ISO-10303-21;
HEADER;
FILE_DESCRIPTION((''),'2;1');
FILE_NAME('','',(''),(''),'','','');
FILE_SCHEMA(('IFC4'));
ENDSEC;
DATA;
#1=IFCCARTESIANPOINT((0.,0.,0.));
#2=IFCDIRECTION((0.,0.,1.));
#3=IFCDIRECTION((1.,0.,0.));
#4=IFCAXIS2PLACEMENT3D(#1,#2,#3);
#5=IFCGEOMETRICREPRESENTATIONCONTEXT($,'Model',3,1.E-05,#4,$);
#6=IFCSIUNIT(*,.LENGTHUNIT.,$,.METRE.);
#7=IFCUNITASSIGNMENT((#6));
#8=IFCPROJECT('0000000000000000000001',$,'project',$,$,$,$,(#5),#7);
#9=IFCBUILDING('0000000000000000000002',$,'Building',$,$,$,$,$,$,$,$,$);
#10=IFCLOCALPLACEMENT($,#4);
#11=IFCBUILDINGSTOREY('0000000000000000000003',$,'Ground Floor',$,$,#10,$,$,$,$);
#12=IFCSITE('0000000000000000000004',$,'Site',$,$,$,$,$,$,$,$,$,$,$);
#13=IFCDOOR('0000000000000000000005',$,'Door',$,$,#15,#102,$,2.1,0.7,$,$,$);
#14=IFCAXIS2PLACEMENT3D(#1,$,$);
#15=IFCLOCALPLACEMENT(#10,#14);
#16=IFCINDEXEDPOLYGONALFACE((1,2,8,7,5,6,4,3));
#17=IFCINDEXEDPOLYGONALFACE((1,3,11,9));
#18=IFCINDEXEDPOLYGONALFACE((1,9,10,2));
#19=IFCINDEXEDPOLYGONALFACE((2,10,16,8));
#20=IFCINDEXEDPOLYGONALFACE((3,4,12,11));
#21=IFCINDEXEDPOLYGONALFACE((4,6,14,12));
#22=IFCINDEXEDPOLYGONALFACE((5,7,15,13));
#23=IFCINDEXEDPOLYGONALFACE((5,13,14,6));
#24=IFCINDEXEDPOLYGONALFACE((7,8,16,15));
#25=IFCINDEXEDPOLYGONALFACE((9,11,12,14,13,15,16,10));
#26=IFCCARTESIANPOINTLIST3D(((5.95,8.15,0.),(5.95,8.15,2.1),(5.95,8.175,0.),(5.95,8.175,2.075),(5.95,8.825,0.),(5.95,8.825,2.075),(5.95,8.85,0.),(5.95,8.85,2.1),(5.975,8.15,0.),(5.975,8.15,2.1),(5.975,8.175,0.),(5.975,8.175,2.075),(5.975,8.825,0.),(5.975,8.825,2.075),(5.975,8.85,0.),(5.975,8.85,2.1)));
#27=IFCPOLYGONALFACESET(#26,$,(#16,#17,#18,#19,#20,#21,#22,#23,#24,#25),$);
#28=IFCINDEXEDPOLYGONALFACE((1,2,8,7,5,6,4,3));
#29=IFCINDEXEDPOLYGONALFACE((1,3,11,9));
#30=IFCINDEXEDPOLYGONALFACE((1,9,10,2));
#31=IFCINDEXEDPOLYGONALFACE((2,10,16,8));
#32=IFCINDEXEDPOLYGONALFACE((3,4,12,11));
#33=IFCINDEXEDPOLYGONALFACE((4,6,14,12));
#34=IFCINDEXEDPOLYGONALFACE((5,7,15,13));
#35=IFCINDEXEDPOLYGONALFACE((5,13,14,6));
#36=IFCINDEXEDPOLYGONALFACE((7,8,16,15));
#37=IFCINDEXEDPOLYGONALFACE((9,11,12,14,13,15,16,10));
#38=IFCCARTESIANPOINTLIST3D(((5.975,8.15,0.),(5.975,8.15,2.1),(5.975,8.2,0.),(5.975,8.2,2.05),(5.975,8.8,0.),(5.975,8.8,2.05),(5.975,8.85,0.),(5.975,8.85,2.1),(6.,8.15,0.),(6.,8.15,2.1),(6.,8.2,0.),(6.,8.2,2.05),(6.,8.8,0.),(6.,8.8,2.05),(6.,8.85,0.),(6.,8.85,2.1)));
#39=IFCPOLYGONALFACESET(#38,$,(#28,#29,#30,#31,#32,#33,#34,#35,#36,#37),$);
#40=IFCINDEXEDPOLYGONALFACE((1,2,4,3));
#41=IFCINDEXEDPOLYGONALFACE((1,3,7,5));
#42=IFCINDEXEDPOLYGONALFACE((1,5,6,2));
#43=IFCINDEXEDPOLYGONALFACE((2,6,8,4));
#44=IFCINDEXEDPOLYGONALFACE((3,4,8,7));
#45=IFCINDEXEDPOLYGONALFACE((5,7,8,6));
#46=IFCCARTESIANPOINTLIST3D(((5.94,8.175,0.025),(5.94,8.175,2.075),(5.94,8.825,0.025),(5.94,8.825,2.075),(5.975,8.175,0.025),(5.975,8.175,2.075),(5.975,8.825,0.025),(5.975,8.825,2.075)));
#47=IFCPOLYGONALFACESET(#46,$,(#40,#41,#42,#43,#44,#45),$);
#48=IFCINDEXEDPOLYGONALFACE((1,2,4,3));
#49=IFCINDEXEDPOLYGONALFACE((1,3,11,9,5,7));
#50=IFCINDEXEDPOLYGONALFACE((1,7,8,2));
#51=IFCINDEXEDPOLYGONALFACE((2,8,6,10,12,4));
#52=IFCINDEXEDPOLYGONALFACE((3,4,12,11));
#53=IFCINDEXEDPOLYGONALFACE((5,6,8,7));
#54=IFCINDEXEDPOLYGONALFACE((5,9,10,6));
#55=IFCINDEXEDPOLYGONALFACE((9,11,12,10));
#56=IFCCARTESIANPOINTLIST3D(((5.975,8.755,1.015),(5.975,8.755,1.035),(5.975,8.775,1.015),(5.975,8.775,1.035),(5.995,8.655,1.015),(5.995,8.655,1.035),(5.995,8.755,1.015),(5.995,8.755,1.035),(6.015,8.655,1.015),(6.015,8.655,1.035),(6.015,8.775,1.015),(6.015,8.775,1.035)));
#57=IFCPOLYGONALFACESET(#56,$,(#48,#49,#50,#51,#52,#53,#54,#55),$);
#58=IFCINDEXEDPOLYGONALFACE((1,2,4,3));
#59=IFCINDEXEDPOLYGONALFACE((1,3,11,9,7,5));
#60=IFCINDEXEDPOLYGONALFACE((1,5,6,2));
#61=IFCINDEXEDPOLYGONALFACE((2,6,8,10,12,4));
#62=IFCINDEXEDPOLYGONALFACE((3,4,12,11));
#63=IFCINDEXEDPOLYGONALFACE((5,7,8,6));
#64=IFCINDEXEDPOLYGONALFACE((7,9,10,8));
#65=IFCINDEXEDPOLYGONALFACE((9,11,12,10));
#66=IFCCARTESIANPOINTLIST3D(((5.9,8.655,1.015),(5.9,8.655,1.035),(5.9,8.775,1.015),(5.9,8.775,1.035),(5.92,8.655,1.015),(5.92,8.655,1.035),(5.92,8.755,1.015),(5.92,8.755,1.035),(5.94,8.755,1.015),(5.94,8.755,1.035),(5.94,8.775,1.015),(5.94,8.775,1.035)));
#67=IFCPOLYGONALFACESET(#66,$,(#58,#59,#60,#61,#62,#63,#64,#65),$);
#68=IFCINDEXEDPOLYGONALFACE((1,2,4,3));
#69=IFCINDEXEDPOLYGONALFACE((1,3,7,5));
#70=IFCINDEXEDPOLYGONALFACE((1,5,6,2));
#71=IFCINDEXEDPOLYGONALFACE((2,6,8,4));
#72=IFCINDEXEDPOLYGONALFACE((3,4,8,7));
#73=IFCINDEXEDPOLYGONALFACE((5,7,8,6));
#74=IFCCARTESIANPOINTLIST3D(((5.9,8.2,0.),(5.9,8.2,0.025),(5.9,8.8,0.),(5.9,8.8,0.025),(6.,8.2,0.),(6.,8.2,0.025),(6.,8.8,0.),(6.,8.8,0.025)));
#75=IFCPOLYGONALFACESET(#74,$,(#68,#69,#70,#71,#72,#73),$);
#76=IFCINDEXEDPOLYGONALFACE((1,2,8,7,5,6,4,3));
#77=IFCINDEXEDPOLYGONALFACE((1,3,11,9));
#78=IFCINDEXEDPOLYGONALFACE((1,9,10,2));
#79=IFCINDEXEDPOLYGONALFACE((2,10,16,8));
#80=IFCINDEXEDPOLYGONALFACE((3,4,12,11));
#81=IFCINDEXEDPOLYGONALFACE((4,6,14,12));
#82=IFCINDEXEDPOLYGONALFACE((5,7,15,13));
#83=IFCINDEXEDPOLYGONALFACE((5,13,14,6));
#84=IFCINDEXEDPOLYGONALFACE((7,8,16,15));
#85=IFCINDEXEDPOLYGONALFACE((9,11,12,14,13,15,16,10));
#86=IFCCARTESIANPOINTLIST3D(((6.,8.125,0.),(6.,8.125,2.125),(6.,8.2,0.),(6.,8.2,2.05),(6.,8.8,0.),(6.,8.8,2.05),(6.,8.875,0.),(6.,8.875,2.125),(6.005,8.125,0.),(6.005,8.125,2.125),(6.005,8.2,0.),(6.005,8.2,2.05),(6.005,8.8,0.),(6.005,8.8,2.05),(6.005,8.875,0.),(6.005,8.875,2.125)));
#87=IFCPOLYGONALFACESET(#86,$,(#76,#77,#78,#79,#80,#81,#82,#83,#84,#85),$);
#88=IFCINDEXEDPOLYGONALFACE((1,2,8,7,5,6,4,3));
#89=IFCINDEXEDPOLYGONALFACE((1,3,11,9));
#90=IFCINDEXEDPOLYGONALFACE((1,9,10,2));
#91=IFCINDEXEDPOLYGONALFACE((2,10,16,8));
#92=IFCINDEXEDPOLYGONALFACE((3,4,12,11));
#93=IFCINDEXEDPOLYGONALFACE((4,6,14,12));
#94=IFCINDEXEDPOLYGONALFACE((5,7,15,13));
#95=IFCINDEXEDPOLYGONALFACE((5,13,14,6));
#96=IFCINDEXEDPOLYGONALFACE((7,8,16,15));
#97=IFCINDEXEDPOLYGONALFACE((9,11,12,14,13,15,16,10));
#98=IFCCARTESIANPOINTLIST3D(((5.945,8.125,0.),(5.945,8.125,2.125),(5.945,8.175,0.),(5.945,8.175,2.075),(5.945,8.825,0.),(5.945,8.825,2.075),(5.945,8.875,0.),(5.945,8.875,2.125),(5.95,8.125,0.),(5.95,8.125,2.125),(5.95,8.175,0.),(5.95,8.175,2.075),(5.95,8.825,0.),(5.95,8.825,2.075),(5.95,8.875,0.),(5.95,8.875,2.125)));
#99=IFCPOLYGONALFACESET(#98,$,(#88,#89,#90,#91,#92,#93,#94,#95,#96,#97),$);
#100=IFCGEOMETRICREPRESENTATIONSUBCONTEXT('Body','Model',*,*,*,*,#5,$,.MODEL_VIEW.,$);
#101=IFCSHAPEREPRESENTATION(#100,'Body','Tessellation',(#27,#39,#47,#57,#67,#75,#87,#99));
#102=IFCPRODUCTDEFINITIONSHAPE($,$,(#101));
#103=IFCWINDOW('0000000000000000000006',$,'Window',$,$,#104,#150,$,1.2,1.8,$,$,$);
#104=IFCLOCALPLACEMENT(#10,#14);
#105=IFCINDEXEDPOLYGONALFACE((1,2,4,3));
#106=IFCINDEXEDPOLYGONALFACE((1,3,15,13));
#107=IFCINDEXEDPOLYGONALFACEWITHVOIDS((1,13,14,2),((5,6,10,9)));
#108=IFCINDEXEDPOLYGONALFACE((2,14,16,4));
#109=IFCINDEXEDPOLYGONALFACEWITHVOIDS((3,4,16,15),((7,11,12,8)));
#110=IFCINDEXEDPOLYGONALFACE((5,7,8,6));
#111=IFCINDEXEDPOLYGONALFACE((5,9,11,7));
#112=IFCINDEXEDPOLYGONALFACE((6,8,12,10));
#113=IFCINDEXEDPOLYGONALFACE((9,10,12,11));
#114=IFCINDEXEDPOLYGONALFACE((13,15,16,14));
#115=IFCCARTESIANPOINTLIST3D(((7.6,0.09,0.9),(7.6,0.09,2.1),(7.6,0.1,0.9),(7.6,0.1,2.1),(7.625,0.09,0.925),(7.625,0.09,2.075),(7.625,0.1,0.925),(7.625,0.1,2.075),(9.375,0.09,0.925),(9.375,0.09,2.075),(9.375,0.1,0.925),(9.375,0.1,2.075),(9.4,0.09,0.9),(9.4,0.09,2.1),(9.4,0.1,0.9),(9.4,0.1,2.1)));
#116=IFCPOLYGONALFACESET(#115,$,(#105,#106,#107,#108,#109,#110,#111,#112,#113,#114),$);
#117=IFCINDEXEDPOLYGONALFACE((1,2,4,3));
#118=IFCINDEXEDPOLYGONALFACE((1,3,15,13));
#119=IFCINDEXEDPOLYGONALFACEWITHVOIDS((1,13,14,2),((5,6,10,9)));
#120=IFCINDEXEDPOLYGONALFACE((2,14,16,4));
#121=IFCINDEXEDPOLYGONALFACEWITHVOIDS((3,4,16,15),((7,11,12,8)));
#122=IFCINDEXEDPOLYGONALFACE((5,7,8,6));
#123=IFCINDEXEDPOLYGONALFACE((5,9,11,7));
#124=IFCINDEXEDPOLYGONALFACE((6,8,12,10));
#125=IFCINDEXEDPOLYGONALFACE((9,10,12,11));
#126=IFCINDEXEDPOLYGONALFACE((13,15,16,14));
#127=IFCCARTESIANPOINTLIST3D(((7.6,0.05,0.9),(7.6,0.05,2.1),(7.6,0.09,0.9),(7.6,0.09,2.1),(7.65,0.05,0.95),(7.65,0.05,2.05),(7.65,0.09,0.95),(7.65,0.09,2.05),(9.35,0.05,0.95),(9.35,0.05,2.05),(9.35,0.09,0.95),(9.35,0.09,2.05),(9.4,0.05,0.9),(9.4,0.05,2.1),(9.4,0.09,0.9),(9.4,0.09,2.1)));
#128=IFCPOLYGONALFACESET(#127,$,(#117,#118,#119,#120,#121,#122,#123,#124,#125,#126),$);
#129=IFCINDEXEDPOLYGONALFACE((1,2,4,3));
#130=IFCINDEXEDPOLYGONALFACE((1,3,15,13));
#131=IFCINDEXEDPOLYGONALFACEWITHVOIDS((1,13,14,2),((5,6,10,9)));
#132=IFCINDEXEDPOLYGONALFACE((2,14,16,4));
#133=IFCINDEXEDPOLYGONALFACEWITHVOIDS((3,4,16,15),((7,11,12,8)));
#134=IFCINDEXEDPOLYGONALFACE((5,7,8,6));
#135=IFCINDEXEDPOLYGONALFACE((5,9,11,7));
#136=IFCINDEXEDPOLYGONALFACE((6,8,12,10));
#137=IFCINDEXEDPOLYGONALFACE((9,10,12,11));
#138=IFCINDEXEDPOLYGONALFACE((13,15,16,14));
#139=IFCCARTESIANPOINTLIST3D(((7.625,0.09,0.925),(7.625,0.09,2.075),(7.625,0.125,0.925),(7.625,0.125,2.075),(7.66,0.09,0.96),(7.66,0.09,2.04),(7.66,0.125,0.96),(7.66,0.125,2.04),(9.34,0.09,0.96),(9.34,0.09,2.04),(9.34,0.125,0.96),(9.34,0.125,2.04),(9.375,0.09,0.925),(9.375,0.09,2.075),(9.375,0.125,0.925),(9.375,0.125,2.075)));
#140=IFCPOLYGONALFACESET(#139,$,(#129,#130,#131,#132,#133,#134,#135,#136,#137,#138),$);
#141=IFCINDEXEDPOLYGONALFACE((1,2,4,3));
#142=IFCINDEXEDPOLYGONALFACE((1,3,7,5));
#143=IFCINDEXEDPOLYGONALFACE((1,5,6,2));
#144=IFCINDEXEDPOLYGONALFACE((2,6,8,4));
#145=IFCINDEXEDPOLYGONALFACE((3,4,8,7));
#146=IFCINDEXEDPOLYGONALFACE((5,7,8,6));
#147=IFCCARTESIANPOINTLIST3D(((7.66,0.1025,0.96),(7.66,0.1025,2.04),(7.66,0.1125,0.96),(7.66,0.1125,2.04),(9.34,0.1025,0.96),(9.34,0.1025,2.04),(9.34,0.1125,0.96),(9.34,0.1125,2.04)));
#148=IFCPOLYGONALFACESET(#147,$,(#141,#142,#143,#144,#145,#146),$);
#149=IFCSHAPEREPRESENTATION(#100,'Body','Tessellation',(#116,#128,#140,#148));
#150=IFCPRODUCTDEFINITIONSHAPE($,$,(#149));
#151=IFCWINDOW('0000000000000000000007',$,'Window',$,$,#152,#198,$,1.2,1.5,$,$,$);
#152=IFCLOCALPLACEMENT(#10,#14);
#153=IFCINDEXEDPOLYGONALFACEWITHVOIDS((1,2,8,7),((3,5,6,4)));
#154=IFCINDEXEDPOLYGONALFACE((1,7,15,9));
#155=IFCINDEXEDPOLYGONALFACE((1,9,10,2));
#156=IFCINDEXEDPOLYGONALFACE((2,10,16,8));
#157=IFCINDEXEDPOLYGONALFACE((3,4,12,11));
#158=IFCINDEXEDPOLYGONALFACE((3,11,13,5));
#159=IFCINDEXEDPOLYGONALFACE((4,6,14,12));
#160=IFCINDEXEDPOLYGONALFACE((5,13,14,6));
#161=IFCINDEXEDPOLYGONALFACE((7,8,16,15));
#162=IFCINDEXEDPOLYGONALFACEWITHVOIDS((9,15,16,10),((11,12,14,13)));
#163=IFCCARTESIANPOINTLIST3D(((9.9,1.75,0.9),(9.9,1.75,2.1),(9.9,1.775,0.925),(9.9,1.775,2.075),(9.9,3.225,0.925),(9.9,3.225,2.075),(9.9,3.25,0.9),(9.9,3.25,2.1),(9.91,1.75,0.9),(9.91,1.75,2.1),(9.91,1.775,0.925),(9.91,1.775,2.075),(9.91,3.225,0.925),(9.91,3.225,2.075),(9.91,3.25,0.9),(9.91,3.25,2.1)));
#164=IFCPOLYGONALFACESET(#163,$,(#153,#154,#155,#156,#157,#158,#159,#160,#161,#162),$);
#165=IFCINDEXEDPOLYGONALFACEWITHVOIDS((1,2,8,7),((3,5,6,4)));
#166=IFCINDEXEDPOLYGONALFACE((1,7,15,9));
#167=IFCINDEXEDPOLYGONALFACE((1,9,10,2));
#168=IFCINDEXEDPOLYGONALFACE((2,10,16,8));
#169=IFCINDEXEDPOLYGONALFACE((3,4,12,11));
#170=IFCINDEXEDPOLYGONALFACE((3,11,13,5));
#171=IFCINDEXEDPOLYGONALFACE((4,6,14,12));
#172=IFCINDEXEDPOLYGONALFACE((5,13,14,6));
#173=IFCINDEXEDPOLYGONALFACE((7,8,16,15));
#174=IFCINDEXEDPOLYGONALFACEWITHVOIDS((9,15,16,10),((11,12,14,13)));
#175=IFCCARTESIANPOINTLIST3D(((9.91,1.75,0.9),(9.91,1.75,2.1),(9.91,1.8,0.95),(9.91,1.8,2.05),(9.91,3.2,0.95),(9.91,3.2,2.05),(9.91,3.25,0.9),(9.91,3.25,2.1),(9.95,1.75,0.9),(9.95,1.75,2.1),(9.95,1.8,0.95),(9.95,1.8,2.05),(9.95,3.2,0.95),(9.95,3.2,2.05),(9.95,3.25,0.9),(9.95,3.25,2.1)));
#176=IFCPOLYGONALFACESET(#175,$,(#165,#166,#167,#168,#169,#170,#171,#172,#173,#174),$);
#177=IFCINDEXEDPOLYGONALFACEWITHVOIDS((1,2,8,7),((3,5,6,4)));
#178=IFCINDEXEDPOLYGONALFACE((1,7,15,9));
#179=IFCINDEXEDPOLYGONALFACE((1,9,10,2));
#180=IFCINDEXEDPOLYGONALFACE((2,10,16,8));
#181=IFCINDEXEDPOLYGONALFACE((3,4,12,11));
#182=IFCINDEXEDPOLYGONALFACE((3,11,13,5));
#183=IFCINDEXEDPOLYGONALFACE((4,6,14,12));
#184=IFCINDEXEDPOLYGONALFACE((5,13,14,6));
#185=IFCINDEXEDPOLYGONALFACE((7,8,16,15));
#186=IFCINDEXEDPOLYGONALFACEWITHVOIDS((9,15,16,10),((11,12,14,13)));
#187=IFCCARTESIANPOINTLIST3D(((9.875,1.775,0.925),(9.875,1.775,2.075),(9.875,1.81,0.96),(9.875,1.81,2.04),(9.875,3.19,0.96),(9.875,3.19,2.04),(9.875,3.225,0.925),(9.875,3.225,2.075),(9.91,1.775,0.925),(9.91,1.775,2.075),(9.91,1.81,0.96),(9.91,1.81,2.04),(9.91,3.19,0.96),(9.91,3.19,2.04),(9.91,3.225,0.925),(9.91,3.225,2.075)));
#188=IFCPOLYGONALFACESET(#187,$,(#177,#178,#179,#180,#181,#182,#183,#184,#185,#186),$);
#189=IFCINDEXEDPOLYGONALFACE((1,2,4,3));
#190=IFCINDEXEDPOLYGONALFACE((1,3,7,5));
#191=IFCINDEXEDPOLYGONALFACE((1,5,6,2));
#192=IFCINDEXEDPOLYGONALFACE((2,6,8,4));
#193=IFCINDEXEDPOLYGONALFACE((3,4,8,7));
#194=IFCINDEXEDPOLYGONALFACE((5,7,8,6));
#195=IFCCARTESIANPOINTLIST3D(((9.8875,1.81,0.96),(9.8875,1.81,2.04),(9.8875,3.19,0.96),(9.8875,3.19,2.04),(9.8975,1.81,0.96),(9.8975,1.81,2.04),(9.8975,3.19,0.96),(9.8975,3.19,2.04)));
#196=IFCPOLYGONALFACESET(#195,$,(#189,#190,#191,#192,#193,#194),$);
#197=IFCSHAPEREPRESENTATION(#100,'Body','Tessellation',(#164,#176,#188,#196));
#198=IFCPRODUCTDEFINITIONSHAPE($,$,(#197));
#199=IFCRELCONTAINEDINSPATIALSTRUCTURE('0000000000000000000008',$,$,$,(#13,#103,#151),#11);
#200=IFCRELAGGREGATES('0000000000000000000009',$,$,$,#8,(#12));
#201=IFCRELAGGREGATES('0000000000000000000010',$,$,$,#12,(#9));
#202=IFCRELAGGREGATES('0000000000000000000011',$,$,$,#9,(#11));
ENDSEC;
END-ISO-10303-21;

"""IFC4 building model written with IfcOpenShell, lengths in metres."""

from ifc_helpers import new_model, si_unit, frame, origin_with_axes, place, context, subcontext, project, spatial, line, indexed_curve, outline, extrude, element, save


model = new_model("IFC4")

# Units and contexts
model_context = context("Model", 3, precision=1e-05, world=origin_with_axes())
body_context = subcontext(model_context, "Body", "Model", "MODEL_VIEW")
ifc_project = project(units=[si_unit("LENGTHUNIT", "METRE")], contexts=[model_context])

# Site, building, storey
site = spatial("IfcSite", under=ifc_project, Name="Site")
building = spatial("IfcBuilding", under=site, Name="Building")
storey_placement = place(None, origin_with_axes())
storey = spatial("IfcBuildingStorey", under=building, at=storey_placement, Name="Ground Floor")

# Door
door_1_placement = place(storey_placement, frame((6.0, 8.15, 0.0), z_axis=(0.0, 0.0, 1.0), x_axis=(0.0, 1.0, 0.0)))
element("IfcDoor", 1, at=door_1_placement, inside=storey, Name="Door", OverallHeight=2.1, OverallWidth=0.7, context=body_context, shape_type="SweptSolid", body=[
    extrude(outline(indexed_curve([(0.0, 0.0), (0.0, 2.1), (0.7, 2.1), (0.7, 0.0), (0.675, 0.0), (0.675, 2.075), (0.025, 2.075), (0.025, 0.0)], segments=[line(1, 2, 3, 4, 5, 6, 7, 8, 1)])), frame((0.0, 0.025, 0.0), z_axis=(0.0, -1.0, 0.0), x_axis=(1.0, 0.0, 0.0)), (0.0, 0.0, -1.0), 0.025),
    extrude(outline(indexed_curve([(0.0, 0.0), (0.0, 2.1), (0.7, 2.1), (0.7, 0.0), (0.65, 0.0), (0.65, 2.05), (0.05, 2.05), (0.05, 0.0)], segments=[line(1, 2, 3, 4, 5, 6, 7, 8, 1)])), frame((0.0, 0.0, 0.0), z_axis=(0.0, -1.0, 0.0), x_axis=(1.0, 0.0, 0.0)), (0.0, 0.0, -1.0), 0.025),
    extrude(outline(indexed_curve([(0.0, 0.0), (0.65, 0.0), (0.65, 0.035), (0.0, 0.035)], segments=[line(1, 2, 3, 4, 1)])), frame((0.025, 0.025, 0.025), z_axis=(0.0, 0.0, 1.0), x_axis=(1.0, 0.0, 0.0)), (0.0, 0.0, 1.0), 2.05),
    extrude(outline(indexed_curve([(0.0, 0.0), (0.0, -0.04), (-0.12, -0.04), (-0.12, -0.02), (-0.02, -0.02), (-0.02, 0.0)], segments=[line(1, 2, 3, 4, 5, 6, 1)])), frame((0.625, 0.025, 1.015), z_axis=(0.0, 0.0, 1.0), x_axis=(1.0, 0.0, 0.0)), (0.0, 0.0, 1.0), 0.02),
    extrude(outline(indexed_curve([(0.0, 0.0), (0.0, 0.04), (-0.12, 0.04), (-0.12, 0.02), (-0.02, 0.02), (-0.02, 0.0)], segments=[line(1, 2, 3, 4, 5, 6, 1)])), frame((0.625, 0.06, 1.015), z_axis=(0.0, 0.0, 1.0), x_axis=(1.0, 0.0, 0.0)), (0.0, 0.0, 1.0), 0.02),
    extrude(outline(indexed_curve([(0.0, 0.0), (0.6, 0.0), (0.6, 0.1), (0.0, 0.1)], segments=[line(1, 2, 3, 4, 1)])), frame((0.05, 0.0, 0.0), z_axis=(0.0, 0.0, 1.0), x_axis=(1.0, 0.0, 0.0)), (0.0, 0.0, 1.0), 0.025),
    extrude(outline(indexed_curve([(0.0, 0.0), (0.0, 2.125), (0.75, 2.125), (0.75, 0.0), (0.675, 0.0), (0.675, 2.05), (0.075, 2.05), (0.075, 0.0)], segments=[line(1, 2, 3, 4, 5, 6, 7, 8, 1)])), frame((-0.025, -0.005, 0.0), z_axis=(0.0, -1.0, 0.0), x_axis=(1.0, 0.0, 0.0)), (0.0, 0.0, -1.0), 0.005),
    extrude(outline(indexed_curve([(0.0, 0.0), (0.0, 2.125), (0.75, 2.125), (0.75, 0.0), (0.7, 0.0), (0.7, 2.075), (0.05, 2.075), (0.05, 0.0)], segments=[line(1, 2, 3, 4, 5, 6, 7, 8, 1)])), frame((-0.025, 0.05, 0.0), z_axis=(0.0, -1.0, 0.0), x_axis=(1.0, 0.0, 0.0)), (0.0, 0.0, -1.0), 0.005),
])

# Windows
window_1_placement = place(storey_placement, frame((7.6, 0.0, 0.9), z_axis=(0.0, 0.0, 1.0), x_axis=(1.0, 0.0, 0.0)))
element("IfcWindow", 2, at=window_1_placement, inside=storey, Name="Window", OverallHeight=1.2, OverallWidth=1.8, context=body_context, shape_type="SweptSolid", body=[
    extrude(outline(indexed_curve([(0.0, 0.0), (1.8, 0.0), (1.8, 1.2), (0.0, 1.2)], segments=[line(1, 2, 3, 4, 1)]), holes=[indexed_curve([(0.025, 0.025), (1.775, 0.025), (1.775, 1.175), (0.025, 1.175)], segments=[line(1, 2, 3, 4, 1)])]), frame((0.0, 0.09, 0.0), z_axis=(0.0, -1.0, 0.0), x_axis=(1.0, 0.0, 0.0)), (0.0, 0.0, -1.0), 0.01),
    extrude(outline(indexed_curve([(0.0, 0.0), (1.8, 0.0), (1.8, 1.2), (0.0, 1.2)], segments=[line(1, 2, 3, 4, 1)]), holes=[indexed_curve([(0.05, 0.05), (1.75, 0.05), (1.75, 1.15), (0.05, 1.15)], segments=[line(1, 2, 3, 4, 1)])]), frame((0.0, 0.05, 0.0), z_axis=(0.0, -1.0, 0.0), x_axis=(1.0, 0.0, 0.0)), (0.0, 0.0, -1.0), 0.04),
    extrude(outline(indexed_curve([(0.0, 0.0), (1.75, 0.0), (1.75, 1.15), (0.0, 1.15)], segments=[line(1, 2, 3, 4, 1)]), holes=[indexed_curve([(0.035, 0.035), (1.715, 0.035), (1.715, 1.115), (0.035, 1.115)], segments=[line(1, 2, 3, 4, 1)])]), frame((0.025, 0.09, 0.025), z_axis=(0.0, -1.0, 0.0), x_axis=(1.0, 0.0, 0.0)), (0.0, 0.0, -1.0), 0.035),
    extrude(outline(indexed_curve([(0.035, 0.035), (1.715, 0.035), (1.715, 1.115), (0.035, 1.115)], segments=[line(1, 2, 3, 4, 1)])), frame((0.025, 0.1025, 0.025), z_axis=(0.0, -1.0, 0.0), x_axis=(1.0, 0.0, 0.0)), (0.0, 0.0, -1.0), 0.01),
])
window_2_placement = place(storey_placement, frame((10.0, 1.75, 0.9), z_axis=(0.0, 0.0, 1.0), x_axis=(0.0, 1.0, 0.0)))
element("IfcWindow", 3, at=window_2_placement, inside=storey, Name="Window", OverallHeight=1.2, OverallWidth=1.5, context=body_context, shape_type="SweptSolid", body=[
    extrude(outline(indexed_curve([(0.0, 0.0), (1.5, 0.0), (1.5, 1.2), (0.0, 1.2)], segments=[line(1, 2, 3, 4, 1)]), holes=[indexed_curve([(0.025, 0.025), (1.475, 0.025), (1.475, 1.175), (0.025, 1.175)], segments=[line(1, 2, 3, 4, 1)])]), frame((0.0, 0.09, 0.0), z_axis=(0.0, -1.0, 0.0), x_axis=(1.0, 0.0, 0.0)), (0.0, 0.0, -1.0), 0.01),
    extrude(outline(indexed_curve([(0.0, 0.0), (1.5, 0.0), (1.5, 1.2), (0.0, 1.2)], segments=[line(1, 2, 3, 4, 1)]), holes=[indexed_curve([(0.05, 0.05), (1.45, 0.05), (1.45, 1.15), (0.05, 1.15)], segments=[line(1, 2, 3, 4, 1)])]), frame((0.0, 0.05, 0.0), z_axis=(0.0, -1.0, 0.0), x_axis=(1.0, 0.0, 0.0)), (0.0, 0.0, -1.0), 0.04),
    extrude(outline(indexed_curve([(0.0, 0.0), (1.45, 0.0), (1.45, 1.15), (0.0, 1.15)], segments=[line(1, 2, 3, 4, 1)]), holes=[indexed_curve([(0.035, 0.035), (1.415, 0.035), (1.415, 1.115), (0.035, 1.115)], segments=[line(1, 2, 3, 4, 1)])]), frame((0.025, 0.09, 0.025), z_axis=(0.0, -1.0, 0.0), x_axis=(1.0, 0.0, 0.0)), (0.0, 0.0, -1.0), 0.035),
    extrude(outline(indexed_curve([(0.035, 0.035), (1.415, 0.035), (1.415, 1.115), (0.035, 1.115)], segments=[line(1, 2, 3, 4, 1)])), frame((0.025, 0.1025, 0.025), z_axis=(0.0, -1.0, 0.0), x_axis=(1.0, 0.0, 0.0)), (0.0, 0.0, -1.0), 0.01),
])

save(model, "model.ifc")
